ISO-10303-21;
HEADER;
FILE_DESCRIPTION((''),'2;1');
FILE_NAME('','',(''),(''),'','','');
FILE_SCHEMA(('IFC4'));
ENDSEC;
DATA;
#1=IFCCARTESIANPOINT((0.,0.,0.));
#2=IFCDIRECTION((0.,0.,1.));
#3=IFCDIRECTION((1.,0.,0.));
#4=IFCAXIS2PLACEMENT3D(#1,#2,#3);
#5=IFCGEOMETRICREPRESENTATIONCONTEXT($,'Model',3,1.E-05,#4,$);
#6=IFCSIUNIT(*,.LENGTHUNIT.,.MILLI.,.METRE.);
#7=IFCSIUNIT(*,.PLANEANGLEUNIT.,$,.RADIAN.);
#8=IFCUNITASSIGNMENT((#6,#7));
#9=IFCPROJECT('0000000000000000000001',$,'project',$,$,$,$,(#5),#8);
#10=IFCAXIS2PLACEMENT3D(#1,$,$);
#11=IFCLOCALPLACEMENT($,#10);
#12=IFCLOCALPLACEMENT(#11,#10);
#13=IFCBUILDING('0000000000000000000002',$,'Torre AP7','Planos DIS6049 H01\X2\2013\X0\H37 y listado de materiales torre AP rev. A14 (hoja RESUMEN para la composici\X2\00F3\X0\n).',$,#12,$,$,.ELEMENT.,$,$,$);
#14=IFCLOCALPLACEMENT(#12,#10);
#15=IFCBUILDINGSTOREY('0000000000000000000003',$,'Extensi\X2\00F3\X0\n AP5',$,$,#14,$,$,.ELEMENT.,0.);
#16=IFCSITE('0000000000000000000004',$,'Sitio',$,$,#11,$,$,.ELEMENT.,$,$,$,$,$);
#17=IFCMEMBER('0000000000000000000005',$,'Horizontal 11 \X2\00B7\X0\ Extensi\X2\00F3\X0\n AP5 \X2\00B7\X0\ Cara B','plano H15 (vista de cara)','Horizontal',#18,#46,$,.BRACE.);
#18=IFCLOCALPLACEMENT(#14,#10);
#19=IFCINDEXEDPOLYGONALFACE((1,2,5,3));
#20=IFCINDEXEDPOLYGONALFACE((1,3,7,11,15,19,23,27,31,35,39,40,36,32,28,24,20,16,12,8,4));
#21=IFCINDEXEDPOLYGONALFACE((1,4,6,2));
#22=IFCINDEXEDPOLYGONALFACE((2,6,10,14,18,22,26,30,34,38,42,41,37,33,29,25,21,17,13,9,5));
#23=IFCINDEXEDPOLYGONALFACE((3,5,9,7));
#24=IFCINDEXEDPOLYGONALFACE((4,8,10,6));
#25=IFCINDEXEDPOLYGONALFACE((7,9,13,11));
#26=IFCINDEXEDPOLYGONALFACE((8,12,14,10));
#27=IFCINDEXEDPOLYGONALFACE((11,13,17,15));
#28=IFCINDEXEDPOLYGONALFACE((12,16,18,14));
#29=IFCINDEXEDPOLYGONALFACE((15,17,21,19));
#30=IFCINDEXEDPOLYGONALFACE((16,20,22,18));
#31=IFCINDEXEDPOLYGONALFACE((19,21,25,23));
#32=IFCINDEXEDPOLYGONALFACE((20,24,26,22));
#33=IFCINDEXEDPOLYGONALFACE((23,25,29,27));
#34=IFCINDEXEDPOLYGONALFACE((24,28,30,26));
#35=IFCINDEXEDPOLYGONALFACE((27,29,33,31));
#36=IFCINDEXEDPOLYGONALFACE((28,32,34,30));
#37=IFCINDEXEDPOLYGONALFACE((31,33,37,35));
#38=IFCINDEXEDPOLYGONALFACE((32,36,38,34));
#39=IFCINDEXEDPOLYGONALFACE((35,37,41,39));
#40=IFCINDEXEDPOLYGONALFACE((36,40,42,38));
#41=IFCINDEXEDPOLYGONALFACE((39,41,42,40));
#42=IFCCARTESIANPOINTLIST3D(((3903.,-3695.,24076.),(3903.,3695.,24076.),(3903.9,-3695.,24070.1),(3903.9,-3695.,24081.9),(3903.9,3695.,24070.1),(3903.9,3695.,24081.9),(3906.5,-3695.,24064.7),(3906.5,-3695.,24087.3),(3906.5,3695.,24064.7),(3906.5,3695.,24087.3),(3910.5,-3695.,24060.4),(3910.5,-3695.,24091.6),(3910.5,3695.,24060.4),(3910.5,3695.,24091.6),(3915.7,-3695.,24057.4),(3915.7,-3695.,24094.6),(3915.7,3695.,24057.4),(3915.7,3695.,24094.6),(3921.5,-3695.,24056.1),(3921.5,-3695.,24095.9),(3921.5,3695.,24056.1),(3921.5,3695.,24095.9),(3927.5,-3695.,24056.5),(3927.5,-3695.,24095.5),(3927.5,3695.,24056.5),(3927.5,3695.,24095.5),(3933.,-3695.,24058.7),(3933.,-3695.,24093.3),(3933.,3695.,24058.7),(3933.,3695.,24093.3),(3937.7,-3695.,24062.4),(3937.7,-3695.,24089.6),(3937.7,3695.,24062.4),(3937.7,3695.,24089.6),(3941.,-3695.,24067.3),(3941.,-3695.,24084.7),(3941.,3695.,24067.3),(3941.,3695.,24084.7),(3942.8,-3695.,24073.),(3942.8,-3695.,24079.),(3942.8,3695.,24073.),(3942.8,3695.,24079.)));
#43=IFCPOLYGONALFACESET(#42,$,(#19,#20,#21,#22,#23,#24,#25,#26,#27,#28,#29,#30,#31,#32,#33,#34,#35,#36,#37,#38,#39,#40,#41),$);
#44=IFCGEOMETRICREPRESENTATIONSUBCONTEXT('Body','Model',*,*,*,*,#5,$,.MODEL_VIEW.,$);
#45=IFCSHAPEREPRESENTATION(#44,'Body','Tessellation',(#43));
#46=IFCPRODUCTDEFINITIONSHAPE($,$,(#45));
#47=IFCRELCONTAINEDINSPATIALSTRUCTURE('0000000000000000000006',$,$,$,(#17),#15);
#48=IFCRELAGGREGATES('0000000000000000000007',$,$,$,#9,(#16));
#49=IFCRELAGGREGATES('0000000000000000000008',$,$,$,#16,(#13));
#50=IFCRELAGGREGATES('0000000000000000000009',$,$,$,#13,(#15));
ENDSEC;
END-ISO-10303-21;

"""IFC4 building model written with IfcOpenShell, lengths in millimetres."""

from ifc_helpers import new_model, si_unit, frame, origin, origin_with_axes, place, context, subcontext, project, spatial, circle, extrude, element, save


model = new_model("IFC4")

# Units and contexts
model_context = context("Model", 3, precision=1e-05, world=origin_with_axes())
body_context = subcontext(model_context, "Body", "Model", "MODEL_VIEW")
ifc_project = project(units=[si_unit("LENGTHUNIT", "METRE", prefix="MILLI"), si_unit("PLANEANGLEUNIT", "RADIAN")], contexts=[model_context])

# Site, building, storey
site_placement = place(None, origin())
site = spatial("IfcSite", under=ifc_project, at=site_placement, Name="Sitio", CompositionType="ELEMENT")
building_placement = place(site_placement, origin())
building = spatial("IfcBuilding", under=site, at=building_placement, Name="Torre AP7", Description="Planos DIS6049 H01–H37 y listado de materiales torre AP rev. A14 (hoja RESUMEN para la composición).", CompositionType="ELEMENT")
storey_placement = place(building_placement, origin())
storey = spatial("IfcBuildingStorey", under=building, at=storey_placement, Name="Extensión AP5", CompositionType="ELEMENT", Elevation=0.0)

# Member
for number, where, z_axis, x_axis, name in (
    (1, (3923.0, 3695.0, 24076.0), (0.0, -1.0, 0.0), (-1.0, 0.0, 0.0), "Horizontal 11 · Extensión AP5 · Cara B"),
):
    element("IfcMember", number, at=place(storey_placement, frame(where, z_axis=z_axis, x_axis=x_axis)), inside=storey, Name=name, Description="plano H15 (vista de cara)", ObjectType="Horizontal", PredefinedType="BRACE", context=body_context, shape_type="SweptSolid", body=[
        extrude(circle(Radius=20.0), None, (0.0, 0.0, 1.0), 7390.0),
    ])

save(model, "model.ifc")
